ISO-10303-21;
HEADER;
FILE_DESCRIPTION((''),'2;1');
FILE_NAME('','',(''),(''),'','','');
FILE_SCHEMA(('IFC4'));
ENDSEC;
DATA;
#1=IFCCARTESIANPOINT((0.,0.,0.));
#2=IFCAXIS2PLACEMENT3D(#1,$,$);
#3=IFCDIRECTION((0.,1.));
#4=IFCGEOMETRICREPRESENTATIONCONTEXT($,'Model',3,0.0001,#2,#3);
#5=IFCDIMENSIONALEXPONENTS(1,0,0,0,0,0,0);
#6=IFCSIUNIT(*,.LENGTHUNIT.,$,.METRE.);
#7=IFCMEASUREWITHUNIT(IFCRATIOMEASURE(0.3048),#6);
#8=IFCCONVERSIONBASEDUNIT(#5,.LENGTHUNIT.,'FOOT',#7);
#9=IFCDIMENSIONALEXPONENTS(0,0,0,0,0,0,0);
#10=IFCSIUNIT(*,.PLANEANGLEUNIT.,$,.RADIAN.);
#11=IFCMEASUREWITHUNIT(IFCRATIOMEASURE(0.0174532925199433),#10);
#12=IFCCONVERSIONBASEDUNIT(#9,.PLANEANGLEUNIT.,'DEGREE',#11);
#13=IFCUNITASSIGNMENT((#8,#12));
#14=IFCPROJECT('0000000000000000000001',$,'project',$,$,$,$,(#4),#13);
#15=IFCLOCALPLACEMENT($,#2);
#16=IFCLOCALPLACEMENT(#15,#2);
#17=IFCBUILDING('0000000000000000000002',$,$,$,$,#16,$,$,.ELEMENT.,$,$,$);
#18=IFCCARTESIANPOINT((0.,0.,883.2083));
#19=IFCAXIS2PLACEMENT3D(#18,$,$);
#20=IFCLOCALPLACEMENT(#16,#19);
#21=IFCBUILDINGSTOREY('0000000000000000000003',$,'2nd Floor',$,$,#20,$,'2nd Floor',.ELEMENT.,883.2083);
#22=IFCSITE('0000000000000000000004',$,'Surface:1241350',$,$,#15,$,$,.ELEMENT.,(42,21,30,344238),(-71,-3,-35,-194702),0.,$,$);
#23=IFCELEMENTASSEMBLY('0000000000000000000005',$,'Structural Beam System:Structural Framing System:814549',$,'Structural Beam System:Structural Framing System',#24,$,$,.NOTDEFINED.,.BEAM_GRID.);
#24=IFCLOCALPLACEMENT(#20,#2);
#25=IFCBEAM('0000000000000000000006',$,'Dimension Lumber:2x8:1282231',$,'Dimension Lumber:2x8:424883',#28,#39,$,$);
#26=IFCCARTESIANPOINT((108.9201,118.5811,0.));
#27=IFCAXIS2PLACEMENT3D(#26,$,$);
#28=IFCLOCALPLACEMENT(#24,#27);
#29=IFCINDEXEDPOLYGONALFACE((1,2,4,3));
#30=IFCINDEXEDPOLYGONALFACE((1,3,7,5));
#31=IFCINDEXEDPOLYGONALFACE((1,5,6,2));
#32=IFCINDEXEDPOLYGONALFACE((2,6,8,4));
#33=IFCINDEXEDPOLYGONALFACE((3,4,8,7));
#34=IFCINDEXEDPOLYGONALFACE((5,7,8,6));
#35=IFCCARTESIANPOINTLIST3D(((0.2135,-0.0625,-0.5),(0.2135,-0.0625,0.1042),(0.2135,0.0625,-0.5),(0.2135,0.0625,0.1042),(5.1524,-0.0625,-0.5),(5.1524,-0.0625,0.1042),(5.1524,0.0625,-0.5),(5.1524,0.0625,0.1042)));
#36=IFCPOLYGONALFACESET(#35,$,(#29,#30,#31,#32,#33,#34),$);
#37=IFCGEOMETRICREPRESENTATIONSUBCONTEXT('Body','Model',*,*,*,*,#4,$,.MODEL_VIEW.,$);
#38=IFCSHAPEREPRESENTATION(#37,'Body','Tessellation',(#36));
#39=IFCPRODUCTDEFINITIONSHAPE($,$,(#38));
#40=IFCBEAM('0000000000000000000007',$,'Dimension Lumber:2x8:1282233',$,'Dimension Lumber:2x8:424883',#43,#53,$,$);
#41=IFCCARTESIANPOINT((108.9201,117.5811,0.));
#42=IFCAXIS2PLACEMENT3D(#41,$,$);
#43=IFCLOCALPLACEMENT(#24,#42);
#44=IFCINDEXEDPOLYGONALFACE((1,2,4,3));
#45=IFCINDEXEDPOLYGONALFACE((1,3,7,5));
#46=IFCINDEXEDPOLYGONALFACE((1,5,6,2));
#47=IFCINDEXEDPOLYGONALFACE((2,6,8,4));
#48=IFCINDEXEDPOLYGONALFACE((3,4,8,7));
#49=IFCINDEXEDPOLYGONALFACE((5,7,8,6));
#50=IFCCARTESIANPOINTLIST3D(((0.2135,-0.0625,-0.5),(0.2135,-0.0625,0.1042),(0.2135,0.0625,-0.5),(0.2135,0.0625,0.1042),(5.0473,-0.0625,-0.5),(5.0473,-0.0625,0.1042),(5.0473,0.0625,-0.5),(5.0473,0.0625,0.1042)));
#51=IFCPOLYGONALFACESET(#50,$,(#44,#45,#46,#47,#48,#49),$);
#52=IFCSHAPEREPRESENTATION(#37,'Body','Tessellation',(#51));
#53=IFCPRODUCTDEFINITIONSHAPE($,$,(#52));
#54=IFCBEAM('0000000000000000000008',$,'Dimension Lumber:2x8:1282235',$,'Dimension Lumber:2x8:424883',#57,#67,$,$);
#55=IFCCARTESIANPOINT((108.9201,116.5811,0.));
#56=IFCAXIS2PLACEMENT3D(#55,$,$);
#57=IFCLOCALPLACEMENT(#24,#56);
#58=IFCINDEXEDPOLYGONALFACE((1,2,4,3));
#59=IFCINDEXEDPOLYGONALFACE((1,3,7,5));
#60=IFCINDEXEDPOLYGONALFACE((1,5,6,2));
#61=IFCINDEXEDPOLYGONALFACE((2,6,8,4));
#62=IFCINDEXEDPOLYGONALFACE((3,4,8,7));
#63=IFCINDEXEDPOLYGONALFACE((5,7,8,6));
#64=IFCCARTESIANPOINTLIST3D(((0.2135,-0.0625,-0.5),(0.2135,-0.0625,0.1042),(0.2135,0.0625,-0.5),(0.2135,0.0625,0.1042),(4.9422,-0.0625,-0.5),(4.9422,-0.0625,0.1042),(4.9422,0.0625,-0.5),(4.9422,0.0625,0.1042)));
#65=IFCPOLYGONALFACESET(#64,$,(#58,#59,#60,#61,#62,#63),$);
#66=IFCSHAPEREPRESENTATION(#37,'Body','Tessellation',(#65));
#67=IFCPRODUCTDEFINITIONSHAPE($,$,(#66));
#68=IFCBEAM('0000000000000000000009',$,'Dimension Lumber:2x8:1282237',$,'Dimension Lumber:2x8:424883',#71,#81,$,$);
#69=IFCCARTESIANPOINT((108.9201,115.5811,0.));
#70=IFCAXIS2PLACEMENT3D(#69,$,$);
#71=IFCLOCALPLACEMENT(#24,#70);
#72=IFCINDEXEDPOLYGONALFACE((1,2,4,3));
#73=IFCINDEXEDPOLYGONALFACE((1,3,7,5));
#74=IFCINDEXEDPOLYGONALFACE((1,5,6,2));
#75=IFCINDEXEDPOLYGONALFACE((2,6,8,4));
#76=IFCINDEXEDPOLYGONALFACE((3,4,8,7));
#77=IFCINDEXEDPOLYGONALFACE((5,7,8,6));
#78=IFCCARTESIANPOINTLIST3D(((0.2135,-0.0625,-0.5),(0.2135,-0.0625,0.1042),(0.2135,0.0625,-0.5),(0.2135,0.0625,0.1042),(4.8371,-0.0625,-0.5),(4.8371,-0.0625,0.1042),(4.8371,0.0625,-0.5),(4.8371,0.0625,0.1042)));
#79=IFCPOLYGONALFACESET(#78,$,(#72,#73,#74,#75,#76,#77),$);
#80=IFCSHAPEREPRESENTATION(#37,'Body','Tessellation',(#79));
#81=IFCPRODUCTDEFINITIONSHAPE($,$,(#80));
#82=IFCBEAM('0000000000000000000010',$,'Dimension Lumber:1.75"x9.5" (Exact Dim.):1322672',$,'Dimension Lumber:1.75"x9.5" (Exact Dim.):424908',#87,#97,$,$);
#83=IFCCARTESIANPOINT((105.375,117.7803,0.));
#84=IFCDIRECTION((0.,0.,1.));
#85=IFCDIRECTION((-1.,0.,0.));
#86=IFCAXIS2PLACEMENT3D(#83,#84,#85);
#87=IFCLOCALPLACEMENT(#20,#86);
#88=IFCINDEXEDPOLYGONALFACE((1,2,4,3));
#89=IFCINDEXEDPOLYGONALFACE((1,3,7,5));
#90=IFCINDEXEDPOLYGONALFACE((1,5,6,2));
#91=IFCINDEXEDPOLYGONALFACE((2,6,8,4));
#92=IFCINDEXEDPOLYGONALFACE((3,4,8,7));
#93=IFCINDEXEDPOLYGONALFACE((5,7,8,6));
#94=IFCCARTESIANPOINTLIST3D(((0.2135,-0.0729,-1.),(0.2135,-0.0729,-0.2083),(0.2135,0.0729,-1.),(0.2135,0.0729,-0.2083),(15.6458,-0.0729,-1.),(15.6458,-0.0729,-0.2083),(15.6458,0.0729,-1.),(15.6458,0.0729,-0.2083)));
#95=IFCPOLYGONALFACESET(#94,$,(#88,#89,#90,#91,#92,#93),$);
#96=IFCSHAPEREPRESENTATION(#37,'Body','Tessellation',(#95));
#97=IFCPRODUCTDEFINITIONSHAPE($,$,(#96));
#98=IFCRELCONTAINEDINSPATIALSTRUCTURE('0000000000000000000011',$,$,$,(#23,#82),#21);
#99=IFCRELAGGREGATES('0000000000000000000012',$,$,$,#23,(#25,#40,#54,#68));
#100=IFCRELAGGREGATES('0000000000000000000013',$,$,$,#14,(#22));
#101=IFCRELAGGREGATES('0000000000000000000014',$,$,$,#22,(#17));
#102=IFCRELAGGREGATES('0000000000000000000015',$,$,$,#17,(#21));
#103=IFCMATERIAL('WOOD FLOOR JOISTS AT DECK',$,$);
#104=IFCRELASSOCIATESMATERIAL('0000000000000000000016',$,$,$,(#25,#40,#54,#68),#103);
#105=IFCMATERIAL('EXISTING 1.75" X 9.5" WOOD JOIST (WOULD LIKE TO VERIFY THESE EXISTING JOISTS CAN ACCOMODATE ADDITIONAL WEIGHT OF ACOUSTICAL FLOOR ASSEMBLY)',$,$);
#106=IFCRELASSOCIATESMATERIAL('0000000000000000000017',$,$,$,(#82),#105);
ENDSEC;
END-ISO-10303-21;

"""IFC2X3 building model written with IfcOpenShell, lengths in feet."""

from ifc_helpers import new_model, entity, si_unit, converted_unit, direction, frame, origin, origin_2d_with_axis, place, context, subcontext, project, spatial, rectangle, extrude, material, element, aggregate, save


model = new_model("IFC2X3")

# Units and contexts
model_context = context("Model", 3, precision=0.0001, world=origin(), true_north=direction((0.0, 1.0)))
body_context = subcontext(model_context, "Body", "Model", "MODEL_VIEW")
ifc_project = project(units=[converted_unit("LENGTHUNIT", "FOOT", entity("IfcRatioMeasure", 0.3048), si_unit("LENGTHUNIT", "METRE"), dimensions=[1, 0, 0, 0, 0, 0, 0]), converted_unit("PLANEANGLEUNIT", "DEGREE", entity("IfcRatioMeasure", 0.0174532925199433), si_unit("PLANEANGLEUNIT", "RADIAN"), dimensions=[0, 0, 0, 0, 0, 0, 0])], contexts=[model_context])

# Site, building, storey
site_placement = place(None, origin())
site = spatial("IfcSite", under=ifc_project, at=site_placement, Name="Surface:1241350", CompositionType="ELEMENT", RefLatitude=(42, 21, 30, 344238), RefLongitude=(-71, -3, -35, -194702), RefElevation=0.0)
building_placement = place(site_placement, origin())
building = spatial("IfcBuilding", under=site, at=building_placement, CompositionType="ELEMENT")
storey_placement = place(building_placement, frame((0.0, 0.0, 883.2083)))
storey = spatial("IfcBuildingStorey", under=building, at=storey_placement, Name="2nd Floor", LongName="2nd Floor", CompositionType="ELEMENT", Elevation=883.2083)

# Element assembly, beams
assembly_placement = place(storey_placement, origin())
assembly = element("IfcElementAssembly", 1, at=assembly_placement, inside=storey, Name="Structural Beam System:Structural Framing System:814549", ObjectType="Structural Beam System:Structural Framing System", AssemblyPlace="NOTDEFINED", PredefinedType="BEAM_GRID")
ifc_material_1 = material(Name="WOOD FLOOR JOISTS AT DECK")
beam_1_placement = place(assembly_placement, frame((108.9201, 118.5811, 0.0)))
beam_1 = element("IfcBeam", 2, at=beam_1_placement, material=ifc_material_1, Name="Dimension Lumber:2x8:1282231", ObjectType="Dimension Lumber:2x8:424883", context=body_context, shape_type="SweptSolid", body=[
    extrude(rectangle(XDim=0.6042, YDim=0.125, at=origin_2d_with_axis()), frame((0.2135, 0.0, -0.1979), z_axis=(1.0, 0.0, 0.0), x_axis=(0.0, 0.0, -1.0)), (0.0, 0.0, 1.0), 4.9389),
])
beam_2_placement = place(assembly_placement, frame((108.9201, 117.5811, 0.0)))
beam_2 = element("IfcBeam", 3, at=beam_2_placement, material=ifc_material_1, Name="Dimension Lumber:2x8:1282233", ObjectType="Dimension Lumber:2x8:424883", context=body_context, shape_type="SweptSolid", body=[
    extrude(rectangle(XDim=0.6042, YDim=0.125, at=origin_2d_with_axis()), frame((0.2135, 0.0, -0.1979), z_axis=(1.0, 0.0, 0.0), x_axis=(0.0, 0.0, -1.0)), (0.0, 0.0, 1.0), 4.8338),
])
beam_3_placement = place(assembly_placement, frame((108.9201, 116.5811, 0.0)))
beam_3 = element("IfcBeam", 4, at=beam_3_placement, material=ifc_material_1, Name="Dimension Lumber:2x8:1282235", ObjectType="Dimension Lumber:2x8:424883", context=body_context, shape_type="SweptSolid", body=[
    extrude(rectangle(XDim=0.6042, YDim=0.125, at=origin_2d_with_axis()), frame((0.2135, 0.0, -0.1979), z_axis=(1.0, 0.0, 0.0), x_axis=(0.0, 0.0, -1.0)), (0.0, 0.0, 1.0), 4.7287),
])
beam_4_placement = place(assembly_placement, frame((108.9201, 115.5811, 0.0)))
beam_4 = element("IfcBeam", 5, at=beam_4_placement, material=ifc_material_1, Name="Dimension Lumber:2x8:1282237", ObjectType="Dimension Lumber:2x8:424883", context=body_context, shape_type="SweptSolid", body=[
    extrude(rectangle(XDim=0.6042, YDim=0.125, at=origin_2d_with_axis()), frame((0.2135, 0.0, -0.1979), z_axis=(1.0, 0.0, 0.0), x_axis=(0.0, 0.0, -1.0)), (0.0, 0.0, 1.0), 4.6236),
])
aggregate(assembly, [beam_1, beam_2, beam_3, beam_4])

# Beam
ifc_material_2 = material(Name="EXISTING 1.75\" X 9.5\" WOOD JOIST (WOULD LIKE TO VERIFY THESE EXISTING JOISTS CAN ACCOMODATE ADDITIONAL WEIGHT OF ACOUSTICAL FLOOR ASSEMBLY)")
beam_5_placement = place(storey_placement, frame((105.375, 117.7803, 0.0), z_axis=(0.0, 0.0, 1.0), x_axis=(-1.0, 0.0, 0.0)))
element("IfcBeam", 6, at=beam_5_placement, inside=storey, material=ifc_material_2, Name="Dimension Lumber:1.75\"x9.5\" (Exact Dim.):1322672", ObjectType="Dimension Lumber:1.75\"x9.5\" (Exact Dim.):424908", context=body_context, shape_type="SweptSolid", body=[
    extrude(rectangle(XDim=0.7917, YDim=0.1458, at=origin_2d_with_axis()), frame((0.2135, 0.0, -0.6042), z_axis=(1.0, 0.0, 0.0), x_axis=(0.0, 0.0, -1.0)), (0.0, 0.0, 1.0), 15.4323),
])

save(model, "model.ifc")
